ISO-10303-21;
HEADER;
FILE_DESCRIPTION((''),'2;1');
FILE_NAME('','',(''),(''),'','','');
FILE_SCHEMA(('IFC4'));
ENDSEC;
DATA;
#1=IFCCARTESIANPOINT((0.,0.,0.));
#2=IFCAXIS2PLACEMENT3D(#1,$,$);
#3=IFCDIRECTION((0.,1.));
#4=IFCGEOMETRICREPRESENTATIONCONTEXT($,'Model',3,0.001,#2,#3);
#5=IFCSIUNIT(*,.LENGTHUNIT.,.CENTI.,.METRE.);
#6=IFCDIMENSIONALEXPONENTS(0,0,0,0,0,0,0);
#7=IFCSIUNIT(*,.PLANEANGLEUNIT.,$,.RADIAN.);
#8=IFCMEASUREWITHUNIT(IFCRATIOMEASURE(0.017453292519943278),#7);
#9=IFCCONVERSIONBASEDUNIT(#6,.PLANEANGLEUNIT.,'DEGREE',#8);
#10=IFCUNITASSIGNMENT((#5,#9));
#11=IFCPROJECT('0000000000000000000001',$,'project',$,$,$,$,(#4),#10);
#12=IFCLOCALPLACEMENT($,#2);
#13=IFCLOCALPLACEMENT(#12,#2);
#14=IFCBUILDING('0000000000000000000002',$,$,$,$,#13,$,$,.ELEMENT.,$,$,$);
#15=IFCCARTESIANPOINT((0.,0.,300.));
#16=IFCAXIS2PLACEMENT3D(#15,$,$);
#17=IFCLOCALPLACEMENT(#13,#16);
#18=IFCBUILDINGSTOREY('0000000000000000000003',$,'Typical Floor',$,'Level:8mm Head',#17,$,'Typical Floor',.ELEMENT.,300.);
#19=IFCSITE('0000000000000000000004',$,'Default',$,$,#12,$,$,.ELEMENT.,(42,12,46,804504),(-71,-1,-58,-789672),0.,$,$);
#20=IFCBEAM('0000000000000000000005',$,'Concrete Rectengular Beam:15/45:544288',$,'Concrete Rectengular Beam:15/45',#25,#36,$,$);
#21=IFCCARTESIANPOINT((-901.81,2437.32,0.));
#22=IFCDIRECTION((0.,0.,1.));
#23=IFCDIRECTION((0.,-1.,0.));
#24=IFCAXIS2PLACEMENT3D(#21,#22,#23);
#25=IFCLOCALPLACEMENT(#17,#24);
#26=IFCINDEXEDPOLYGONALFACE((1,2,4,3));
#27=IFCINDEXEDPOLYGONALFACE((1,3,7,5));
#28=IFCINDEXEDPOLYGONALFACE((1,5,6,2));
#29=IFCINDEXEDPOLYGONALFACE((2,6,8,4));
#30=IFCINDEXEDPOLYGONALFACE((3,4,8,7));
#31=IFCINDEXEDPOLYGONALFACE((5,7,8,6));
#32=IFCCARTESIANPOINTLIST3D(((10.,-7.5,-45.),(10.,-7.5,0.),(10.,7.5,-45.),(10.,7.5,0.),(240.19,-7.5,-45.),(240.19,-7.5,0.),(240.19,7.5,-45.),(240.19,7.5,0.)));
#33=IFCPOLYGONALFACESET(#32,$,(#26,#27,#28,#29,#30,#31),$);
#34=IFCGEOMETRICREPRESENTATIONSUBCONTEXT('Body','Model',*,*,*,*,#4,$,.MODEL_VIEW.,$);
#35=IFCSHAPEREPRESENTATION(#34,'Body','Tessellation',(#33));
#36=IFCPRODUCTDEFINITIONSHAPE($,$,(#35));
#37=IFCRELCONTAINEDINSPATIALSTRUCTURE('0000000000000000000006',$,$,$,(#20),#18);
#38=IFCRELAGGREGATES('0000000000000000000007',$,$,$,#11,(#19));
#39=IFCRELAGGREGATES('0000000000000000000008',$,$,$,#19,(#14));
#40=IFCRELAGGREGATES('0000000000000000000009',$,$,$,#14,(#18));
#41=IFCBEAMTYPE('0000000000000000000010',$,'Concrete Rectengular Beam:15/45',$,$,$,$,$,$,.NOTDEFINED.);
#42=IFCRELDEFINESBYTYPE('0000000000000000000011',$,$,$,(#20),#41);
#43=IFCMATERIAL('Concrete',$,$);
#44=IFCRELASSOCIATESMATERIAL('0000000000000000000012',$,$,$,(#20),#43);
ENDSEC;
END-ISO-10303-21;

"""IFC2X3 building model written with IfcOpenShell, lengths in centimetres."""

from ifc_helpers import new_model, entity, si_unit, converted_unit, direction, frame, frame_2d, origin, place, context, subcontext, project, spatial, rectangle, extrude, material, type_object, element, save


model = new_model("IFC2X3")

# Units and contexts
model_context = context("Model", 3, precision=0.001, world=origin(), true_north=direction((0.0, 1.0)))
body_context = subcontext(model_context, "Body", "Model", "MODEL_VIEW")
ifc_project = project(units=[si_unit("LENGTHUNIT", "METRE", prefix="CENTI"), converted_unit("PLANEANGLEUNIT", "DEGREE", entity("IfcRatioMeasure", 0.017453292519943278), si_unit("PLANEANGLEUNIT", "RADIAN"), dimensions=[0, 0, 0, 0, 0, 0, 0])], contexts=[model_context])

# Site, building, storey
site_placement = place(None, origin())
site = spatial("IfcSite", under=ifc_project, at=site_placement, Name="Default", CompositionType="ELEMENT", RefLatitude=(42, 12, 46, 804504), RefLongitude=(-71, -1, -58, -789672), RefElevation=0.0)
building_placement = place(site_placement, origin())
building = spatial("IfcBuilding", under=site, at=building_placement, CompositionType="ELEMENT")
storey_placement = place(building_placement, frame((0.0, 0.0, 300.0)))
storey = spatial("IfcBuildingStorey", under=building, at=storey_placement, Name="Typical Floor", ObjectType="Level:8mm Head", LongName="Typical Floor", CompositionType="ELEMENT", Elevation=300.0)

# Beam
ifc_material = material(Name="Concrete")
beam_type_1 = type_object("IfcBeamType", Name="Concrete Rectengular Beam:15/45", PredefinedType="NOTDEFINED")
beam_1_placement = place(storey_placement, frame((-901.81, 2437.32, 0.0), z_axis=(0.0, 0.0, 1.0), x_axis=(0.0, -1.0, 0.0)))
element("IfcBeam", 1, at=beam_1_placement, inside=storey, type_object=beam_type_1, material=ifc_material, Name="Concrete Rectengular Beam:15/45:544288", ObjectType="Concrete Rectengular Beam:15/45", context=body_context, shape_type="SweptSolid", body=[
    extrude(rectangle(XDim=45.0, YDim=15.0, at=frame_2d((0.0, 0.0), x_axis=(1.0, 0.0))), frame((10.0, 0.0, -22.5), z_axis=(1.0, 0.0, 0.0), x_axis=(0.0, 0.0, -1.0)), (0.0, 0.0, 1.0), 230.19),
])

save(model, "model.ifc")
